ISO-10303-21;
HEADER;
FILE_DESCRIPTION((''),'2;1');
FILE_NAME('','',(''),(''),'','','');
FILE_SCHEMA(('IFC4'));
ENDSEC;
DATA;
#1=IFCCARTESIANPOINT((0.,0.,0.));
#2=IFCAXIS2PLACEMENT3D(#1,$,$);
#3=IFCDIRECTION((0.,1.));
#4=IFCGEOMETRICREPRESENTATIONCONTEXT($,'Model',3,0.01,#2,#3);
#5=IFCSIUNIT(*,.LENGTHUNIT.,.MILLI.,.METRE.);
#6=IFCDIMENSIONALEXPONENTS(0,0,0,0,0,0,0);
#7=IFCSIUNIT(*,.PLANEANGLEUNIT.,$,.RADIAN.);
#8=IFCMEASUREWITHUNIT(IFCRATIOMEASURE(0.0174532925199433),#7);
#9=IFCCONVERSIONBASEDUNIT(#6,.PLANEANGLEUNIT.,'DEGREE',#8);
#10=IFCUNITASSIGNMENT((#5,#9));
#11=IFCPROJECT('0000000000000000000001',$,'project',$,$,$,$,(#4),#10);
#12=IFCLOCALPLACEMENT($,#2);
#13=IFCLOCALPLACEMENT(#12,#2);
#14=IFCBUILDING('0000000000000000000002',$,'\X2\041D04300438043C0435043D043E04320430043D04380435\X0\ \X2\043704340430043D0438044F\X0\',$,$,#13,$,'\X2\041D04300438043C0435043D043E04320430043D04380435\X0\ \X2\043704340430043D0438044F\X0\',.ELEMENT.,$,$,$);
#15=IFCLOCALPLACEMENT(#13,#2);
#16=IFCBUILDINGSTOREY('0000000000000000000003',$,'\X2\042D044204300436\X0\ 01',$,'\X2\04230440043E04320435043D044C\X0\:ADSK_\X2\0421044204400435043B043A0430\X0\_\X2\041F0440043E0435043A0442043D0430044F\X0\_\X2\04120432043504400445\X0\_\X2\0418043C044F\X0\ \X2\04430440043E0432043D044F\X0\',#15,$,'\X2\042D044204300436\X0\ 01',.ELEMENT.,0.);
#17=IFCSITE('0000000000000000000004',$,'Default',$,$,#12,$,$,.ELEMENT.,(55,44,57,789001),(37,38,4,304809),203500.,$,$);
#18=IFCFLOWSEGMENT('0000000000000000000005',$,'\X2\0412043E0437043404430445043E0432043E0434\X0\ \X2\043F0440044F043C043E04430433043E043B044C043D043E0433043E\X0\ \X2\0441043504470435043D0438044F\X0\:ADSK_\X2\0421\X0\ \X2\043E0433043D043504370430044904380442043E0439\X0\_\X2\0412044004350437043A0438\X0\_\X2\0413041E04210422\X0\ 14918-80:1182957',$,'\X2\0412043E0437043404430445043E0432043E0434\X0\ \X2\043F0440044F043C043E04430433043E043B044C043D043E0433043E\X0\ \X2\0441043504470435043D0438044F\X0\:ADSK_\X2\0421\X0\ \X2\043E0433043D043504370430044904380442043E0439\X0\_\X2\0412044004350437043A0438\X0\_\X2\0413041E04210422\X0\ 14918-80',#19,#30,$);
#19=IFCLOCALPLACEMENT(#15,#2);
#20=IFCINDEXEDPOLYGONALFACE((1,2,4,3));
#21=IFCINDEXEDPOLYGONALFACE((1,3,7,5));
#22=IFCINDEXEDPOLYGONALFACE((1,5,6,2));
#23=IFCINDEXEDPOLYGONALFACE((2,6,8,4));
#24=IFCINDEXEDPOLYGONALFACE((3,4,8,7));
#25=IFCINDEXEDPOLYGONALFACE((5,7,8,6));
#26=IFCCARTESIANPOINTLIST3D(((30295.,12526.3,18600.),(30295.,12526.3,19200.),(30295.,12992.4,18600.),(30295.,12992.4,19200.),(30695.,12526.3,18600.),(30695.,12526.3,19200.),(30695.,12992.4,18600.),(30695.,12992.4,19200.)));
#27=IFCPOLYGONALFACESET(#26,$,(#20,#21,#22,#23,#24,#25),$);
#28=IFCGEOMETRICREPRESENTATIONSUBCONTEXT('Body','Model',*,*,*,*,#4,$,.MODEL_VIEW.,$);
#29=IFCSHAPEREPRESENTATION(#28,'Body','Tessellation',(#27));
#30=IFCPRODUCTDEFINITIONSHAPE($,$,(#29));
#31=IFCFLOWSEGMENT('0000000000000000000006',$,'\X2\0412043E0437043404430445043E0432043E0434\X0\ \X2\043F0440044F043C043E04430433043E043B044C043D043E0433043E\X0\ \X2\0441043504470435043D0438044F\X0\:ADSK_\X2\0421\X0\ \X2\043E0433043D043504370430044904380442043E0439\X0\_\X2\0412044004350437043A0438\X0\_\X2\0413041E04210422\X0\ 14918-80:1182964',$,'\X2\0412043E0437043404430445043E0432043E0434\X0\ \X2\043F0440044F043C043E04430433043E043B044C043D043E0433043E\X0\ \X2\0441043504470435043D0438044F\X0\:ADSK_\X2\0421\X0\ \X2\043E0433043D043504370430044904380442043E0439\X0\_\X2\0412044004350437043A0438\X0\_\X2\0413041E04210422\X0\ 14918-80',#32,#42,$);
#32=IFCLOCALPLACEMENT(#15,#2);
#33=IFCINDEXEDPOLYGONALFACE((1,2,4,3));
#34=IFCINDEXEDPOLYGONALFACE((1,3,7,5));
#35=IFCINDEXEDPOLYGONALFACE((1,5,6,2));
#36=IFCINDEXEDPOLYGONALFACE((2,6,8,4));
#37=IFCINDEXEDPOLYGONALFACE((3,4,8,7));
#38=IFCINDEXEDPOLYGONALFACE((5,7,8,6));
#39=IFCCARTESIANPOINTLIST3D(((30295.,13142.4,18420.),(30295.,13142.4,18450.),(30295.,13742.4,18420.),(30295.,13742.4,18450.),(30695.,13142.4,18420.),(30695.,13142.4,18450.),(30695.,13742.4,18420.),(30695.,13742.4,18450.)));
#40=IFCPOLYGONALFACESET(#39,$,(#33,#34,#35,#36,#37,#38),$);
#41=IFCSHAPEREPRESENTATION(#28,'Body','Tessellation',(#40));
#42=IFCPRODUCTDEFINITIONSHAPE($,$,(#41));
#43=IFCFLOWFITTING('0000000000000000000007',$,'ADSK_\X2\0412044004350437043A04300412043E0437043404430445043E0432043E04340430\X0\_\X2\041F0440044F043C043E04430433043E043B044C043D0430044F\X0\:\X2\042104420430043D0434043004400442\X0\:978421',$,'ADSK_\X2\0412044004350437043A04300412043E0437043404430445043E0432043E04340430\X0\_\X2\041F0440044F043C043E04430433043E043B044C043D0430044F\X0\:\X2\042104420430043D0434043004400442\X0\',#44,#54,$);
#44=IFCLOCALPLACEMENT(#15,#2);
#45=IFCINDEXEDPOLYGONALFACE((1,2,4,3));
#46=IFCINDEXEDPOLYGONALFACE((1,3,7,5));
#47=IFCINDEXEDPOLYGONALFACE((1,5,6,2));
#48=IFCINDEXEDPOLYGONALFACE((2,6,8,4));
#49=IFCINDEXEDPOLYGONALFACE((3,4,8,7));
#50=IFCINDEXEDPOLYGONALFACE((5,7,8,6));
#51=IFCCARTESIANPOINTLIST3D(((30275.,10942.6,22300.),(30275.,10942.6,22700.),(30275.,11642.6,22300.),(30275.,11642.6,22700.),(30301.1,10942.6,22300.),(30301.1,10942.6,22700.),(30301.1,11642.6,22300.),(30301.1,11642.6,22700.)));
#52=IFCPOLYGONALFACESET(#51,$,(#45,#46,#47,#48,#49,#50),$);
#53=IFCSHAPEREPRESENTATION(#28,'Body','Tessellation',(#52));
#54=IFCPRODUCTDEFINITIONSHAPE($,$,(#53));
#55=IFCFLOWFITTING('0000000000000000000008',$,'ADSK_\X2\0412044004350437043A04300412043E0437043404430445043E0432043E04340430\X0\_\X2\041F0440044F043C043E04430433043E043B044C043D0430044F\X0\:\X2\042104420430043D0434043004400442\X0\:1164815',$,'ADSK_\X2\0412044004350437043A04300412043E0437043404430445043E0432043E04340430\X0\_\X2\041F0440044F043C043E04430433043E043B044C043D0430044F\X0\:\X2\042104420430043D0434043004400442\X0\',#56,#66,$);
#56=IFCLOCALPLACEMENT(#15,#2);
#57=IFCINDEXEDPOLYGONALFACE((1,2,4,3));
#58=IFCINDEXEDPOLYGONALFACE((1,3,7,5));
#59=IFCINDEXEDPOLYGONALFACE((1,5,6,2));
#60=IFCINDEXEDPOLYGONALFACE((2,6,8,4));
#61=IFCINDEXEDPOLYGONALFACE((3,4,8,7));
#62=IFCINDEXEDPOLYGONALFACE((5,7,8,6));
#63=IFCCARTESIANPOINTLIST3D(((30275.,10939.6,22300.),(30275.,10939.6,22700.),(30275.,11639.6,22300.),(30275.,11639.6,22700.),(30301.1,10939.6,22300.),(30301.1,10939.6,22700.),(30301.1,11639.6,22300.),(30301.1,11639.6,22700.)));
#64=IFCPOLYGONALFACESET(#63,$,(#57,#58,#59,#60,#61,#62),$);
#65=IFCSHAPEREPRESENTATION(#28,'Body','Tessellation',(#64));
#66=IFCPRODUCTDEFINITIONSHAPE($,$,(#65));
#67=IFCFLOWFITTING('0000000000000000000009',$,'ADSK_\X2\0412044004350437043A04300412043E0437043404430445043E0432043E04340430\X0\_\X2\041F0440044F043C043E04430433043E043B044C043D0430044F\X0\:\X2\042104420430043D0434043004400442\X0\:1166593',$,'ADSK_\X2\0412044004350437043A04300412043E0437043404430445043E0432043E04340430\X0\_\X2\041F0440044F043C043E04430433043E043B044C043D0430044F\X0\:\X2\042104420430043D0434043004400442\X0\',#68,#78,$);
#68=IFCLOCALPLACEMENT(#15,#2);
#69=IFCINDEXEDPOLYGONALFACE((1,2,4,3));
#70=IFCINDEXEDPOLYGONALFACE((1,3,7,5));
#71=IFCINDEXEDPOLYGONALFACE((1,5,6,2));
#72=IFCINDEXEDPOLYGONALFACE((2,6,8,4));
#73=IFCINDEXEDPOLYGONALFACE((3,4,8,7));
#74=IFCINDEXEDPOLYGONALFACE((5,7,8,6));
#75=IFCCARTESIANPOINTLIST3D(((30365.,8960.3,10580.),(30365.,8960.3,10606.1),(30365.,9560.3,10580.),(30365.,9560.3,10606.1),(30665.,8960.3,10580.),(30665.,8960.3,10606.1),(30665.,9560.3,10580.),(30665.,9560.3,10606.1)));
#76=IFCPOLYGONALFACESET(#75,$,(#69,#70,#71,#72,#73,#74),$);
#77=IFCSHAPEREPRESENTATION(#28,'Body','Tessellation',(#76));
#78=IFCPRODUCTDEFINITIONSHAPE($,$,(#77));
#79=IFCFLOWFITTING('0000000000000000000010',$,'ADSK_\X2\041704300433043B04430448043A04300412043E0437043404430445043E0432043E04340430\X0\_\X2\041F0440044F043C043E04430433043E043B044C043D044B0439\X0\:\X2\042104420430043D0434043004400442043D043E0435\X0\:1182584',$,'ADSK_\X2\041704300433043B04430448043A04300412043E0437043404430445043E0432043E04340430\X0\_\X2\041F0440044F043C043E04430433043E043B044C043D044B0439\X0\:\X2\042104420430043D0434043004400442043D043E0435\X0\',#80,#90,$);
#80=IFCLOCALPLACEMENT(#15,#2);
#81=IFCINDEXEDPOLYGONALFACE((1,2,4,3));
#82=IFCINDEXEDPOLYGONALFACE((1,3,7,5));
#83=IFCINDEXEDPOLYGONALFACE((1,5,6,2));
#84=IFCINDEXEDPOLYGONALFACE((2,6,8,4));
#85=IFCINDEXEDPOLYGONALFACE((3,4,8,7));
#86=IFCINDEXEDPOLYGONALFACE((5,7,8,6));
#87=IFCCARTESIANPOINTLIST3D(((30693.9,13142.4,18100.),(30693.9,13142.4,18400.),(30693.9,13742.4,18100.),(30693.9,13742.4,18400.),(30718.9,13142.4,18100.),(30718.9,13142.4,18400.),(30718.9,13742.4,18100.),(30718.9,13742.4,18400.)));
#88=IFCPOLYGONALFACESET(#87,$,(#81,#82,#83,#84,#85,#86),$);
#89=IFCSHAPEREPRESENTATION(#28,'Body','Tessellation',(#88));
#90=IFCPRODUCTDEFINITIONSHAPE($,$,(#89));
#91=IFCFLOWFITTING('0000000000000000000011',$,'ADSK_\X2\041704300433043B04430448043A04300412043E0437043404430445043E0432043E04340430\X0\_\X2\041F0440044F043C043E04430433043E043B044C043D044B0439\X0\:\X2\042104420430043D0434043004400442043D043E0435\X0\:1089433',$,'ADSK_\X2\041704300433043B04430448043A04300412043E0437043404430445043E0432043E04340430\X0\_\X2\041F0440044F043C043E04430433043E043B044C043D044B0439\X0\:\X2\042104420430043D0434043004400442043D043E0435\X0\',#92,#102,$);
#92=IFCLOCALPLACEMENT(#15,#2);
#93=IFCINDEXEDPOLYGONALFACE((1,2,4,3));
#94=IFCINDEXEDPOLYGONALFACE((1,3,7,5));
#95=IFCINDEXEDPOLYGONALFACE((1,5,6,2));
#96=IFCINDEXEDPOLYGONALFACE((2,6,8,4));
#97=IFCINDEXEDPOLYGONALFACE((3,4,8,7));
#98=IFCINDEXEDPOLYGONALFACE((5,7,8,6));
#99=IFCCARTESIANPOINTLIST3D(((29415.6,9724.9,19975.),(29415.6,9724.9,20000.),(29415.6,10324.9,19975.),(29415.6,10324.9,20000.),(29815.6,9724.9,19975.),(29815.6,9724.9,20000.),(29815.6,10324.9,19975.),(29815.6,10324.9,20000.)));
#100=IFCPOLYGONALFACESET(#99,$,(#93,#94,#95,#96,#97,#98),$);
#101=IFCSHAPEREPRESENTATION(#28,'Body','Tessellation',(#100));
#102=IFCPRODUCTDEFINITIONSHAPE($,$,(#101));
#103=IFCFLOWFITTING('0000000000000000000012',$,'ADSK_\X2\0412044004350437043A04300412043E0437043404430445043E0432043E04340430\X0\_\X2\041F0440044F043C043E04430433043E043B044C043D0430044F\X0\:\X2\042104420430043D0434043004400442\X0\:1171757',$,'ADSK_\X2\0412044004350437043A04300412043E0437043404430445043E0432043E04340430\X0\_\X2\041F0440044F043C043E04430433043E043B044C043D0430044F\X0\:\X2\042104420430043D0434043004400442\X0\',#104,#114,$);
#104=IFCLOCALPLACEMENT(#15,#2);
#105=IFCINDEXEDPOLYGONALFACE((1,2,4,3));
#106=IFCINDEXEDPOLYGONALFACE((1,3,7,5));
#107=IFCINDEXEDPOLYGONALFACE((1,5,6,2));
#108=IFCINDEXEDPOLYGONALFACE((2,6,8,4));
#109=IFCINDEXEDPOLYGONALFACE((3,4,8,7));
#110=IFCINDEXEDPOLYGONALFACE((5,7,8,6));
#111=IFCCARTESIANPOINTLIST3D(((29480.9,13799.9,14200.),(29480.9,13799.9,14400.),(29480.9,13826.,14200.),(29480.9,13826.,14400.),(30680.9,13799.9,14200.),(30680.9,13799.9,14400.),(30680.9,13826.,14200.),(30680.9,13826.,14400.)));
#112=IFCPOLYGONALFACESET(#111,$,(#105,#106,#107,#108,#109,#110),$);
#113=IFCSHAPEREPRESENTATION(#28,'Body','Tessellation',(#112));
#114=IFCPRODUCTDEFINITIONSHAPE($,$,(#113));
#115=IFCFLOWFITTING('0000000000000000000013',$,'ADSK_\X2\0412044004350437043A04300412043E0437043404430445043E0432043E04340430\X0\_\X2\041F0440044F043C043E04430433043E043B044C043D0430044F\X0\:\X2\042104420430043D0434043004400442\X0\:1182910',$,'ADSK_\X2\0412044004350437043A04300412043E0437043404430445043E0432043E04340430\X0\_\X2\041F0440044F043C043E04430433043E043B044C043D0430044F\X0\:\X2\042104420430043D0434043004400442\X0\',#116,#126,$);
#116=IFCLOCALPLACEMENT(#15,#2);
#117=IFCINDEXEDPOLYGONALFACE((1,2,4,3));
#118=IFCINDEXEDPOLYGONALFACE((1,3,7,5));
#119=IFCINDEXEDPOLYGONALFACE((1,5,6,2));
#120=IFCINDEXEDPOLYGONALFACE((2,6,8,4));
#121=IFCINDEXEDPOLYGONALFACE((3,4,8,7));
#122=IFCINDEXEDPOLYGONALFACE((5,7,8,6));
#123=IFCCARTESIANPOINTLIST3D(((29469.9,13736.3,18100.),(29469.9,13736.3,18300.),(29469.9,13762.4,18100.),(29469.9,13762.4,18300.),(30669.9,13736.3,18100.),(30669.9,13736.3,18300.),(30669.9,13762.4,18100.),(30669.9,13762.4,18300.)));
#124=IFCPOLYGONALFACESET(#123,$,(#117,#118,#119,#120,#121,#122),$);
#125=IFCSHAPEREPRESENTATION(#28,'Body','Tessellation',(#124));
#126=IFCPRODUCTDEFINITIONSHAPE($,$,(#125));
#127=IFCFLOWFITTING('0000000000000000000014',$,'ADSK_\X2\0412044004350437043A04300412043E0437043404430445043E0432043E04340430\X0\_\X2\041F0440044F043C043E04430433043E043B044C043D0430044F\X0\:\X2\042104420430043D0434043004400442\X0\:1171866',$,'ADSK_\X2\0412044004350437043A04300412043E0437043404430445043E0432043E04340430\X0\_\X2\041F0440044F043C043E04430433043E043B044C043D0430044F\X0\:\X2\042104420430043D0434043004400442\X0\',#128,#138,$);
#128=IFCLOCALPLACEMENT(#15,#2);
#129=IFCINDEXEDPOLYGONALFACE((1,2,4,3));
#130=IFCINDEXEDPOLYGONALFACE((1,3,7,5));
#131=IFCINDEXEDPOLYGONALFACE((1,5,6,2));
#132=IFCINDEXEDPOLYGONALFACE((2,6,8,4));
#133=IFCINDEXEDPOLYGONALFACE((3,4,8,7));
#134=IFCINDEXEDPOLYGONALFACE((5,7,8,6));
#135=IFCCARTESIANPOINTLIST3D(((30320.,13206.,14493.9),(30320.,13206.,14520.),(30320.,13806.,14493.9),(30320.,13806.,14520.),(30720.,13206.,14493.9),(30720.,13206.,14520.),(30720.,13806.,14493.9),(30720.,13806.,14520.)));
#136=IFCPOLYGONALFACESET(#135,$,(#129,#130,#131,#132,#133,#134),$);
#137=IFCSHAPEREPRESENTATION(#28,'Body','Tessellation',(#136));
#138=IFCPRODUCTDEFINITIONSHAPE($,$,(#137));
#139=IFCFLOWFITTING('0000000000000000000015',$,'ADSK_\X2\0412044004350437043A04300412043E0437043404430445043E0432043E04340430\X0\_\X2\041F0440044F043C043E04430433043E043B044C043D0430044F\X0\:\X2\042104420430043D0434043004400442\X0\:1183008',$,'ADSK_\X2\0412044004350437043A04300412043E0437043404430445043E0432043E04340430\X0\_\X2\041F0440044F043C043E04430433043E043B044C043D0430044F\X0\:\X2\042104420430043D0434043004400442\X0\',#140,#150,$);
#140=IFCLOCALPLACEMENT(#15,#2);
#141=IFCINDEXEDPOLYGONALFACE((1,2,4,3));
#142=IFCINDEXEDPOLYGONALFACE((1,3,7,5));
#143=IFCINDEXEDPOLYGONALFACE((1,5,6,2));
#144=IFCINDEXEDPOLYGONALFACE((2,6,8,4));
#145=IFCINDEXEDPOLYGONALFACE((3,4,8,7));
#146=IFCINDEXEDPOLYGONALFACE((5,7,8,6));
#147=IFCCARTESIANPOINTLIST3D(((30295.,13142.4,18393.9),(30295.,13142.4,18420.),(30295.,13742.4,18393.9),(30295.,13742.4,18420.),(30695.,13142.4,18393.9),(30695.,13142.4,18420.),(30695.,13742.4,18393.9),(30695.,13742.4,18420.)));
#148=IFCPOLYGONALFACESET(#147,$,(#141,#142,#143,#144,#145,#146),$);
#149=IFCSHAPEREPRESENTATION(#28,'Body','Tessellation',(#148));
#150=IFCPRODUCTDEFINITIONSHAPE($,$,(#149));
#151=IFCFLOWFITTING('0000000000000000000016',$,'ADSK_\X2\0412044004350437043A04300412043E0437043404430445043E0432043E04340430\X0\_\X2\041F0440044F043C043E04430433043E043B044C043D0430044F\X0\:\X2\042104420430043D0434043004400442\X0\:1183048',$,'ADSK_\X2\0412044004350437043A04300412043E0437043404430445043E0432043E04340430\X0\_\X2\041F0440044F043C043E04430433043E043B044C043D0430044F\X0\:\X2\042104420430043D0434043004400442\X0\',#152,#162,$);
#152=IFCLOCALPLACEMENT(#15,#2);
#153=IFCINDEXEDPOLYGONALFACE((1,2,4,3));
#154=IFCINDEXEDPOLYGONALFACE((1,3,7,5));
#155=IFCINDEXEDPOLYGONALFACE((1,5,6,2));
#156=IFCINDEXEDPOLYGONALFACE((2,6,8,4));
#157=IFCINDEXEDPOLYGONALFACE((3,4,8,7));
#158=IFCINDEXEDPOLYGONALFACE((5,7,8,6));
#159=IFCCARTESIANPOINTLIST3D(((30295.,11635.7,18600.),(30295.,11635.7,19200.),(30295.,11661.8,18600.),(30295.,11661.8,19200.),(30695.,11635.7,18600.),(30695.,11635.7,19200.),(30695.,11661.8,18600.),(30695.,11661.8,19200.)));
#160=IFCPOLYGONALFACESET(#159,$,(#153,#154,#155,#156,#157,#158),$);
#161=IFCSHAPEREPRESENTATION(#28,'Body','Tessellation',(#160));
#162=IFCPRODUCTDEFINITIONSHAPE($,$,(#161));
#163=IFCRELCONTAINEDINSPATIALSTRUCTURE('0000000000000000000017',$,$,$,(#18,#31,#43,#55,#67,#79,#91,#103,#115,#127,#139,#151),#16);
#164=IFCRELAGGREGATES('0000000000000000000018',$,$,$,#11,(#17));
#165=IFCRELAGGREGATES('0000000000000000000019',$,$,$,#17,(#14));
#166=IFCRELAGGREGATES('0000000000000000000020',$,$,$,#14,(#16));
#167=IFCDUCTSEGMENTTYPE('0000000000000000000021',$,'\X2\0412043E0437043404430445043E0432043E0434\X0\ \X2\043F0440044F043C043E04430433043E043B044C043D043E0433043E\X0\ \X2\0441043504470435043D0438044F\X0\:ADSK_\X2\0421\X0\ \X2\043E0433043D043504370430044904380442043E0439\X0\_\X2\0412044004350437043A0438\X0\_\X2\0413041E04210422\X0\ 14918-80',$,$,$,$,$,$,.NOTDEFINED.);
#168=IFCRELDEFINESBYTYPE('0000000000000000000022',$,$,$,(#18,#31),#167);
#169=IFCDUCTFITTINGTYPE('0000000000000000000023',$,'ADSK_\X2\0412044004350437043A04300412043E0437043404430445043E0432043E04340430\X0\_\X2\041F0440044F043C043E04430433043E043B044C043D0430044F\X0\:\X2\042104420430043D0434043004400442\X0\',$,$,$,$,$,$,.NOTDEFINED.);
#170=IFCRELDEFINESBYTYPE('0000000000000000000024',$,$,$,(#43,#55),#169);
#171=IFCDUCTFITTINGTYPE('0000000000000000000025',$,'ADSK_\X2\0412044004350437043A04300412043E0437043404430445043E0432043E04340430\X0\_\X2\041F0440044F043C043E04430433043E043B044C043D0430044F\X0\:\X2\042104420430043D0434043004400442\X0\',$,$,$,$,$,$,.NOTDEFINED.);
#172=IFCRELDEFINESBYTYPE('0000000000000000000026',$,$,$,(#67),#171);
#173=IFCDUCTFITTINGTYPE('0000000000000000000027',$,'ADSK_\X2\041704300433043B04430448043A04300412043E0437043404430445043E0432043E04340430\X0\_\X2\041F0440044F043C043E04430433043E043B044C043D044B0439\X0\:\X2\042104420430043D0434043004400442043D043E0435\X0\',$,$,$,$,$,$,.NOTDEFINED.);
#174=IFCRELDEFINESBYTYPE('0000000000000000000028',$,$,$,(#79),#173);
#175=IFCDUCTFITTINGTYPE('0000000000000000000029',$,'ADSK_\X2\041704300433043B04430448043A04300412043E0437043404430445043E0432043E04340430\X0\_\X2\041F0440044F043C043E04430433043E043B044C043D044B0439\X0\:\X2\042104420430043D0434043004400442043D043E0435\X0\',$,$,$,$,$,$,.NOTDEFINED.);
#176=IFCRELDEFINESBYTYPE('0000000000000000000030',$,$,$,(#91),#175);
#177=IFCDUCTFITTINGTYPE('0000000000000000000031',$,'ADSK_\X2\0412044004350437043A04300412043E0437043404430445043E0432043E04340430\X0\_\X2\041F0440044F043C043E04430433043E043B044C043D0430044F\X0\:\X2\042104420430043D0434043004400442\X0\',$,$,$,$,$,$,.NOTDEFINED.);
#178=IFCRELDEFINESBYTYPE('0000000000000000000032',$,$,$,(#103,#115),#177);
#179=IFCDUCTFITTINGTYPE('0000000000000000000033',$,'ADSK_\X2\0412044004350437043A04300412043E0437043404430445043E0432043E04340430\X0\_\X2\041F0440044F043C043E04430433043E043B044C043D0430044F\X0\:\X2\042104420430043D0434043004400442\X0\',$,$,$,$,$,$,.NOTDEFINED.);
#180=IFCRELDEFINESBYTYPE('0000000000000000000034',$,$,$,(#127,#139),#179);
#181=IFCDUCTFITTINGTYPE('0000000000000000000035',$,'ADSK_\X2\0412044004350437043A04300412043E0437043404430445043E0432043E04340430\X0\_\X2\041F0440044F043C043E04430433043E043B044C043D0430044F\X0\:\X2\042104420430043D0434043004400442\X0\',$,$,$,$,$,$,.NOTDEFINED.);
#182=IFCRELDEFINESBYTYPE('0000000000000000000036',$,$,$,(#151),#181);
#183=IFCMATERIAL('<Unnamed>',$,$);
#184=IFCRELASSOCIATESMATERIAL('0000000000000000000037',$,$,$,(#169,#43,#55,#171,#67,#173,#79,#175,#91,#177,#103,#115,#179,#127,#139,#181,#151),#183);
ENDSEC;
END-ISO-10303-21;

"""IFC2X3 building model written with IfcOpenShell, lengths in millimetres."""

from ifc_helpers import new_model, entity, si_unit, converted_unit, direction, frame, origin, origin_2d_with_axis, place, context, subcontext, project, spatial, rectangle, extrude, source, transform, mapped, material, type_object, type_shapes, element, save


model = new_model("IFC2X3")

# Units and contexts
model_context = context("Model", 3, precision=0.01, world=origin(), true_north=direction((0.0, 1.0)))
body_context = subcontext(model_context, "Body", "Model", "MODEL_VIEW")
ifc_project = project(units=[si_unit("LENGTHUNIT", "METRE", prefix="MILLI"), converted_unit("PLANEANGLEUNIT", "DEGREE", entity("IfcRatioMeasure", 0.0174532925199433), si_unit("PLANEANGLEUNIT", "RADIAN"), dimensions=[0, 0, 0, 0, 0, 0, 0])], contexts=[model_context])

# Site, building, storey
site_placement = place(None, origin())
site = spatial("IfcSite", under=ifc_project, at=site_placement, Name="Default", CompositionType="ELEMENT", RefLatitude=(55, 44, 57, 789001), RefLongitude=(37, 38, 4, 304809), RefElevation=203500.0)
building_placement = place(site_placement, origin())
building = spatial("IfcBuilding", under=site, at=building_placement, Name="Наименование здания", LongName="Наименование здания", CompositionType="ELEMENT")
storey_placement = place(building_placement, origin())
storey = spatial("IfcBuildingStorey", under=building, at=storey_placement, Name="Этаж 01", ObjectType="Уровень:ADSK_Стрелка_Проектная_Вверх_Имя уровня", LongName="Этаж 01", CompositionType="ELEMENT", Elevation=0.0)

# Flow segments
duct_segment_type = type_object("IfcDuctSegmentType", Name="Воздуховод прямоугольного сечения:ADSK_С огнезащитой_Врезки_ГОСТ 14918-80", PredefinedType="NOTDEFINED")
flow_segment_1_placement = place(storey_placement, frame((30295.0, 12526.3, 18600.0)))
element("IfcFlowSegment", 1, at=flow_segment_1_placement, inside=storey, type_object=duct_segment_type, Name="Воздуховод прямоугольного сечения:ADSK_С огнезащитой_Врезки_ГОСТ 14918-80:1182957", ObjectType="Воздуховод прямоугольного сечения:ADSK_С огнезащитой_Врезки_ГОСТ 14918-80", context=body_context, shape_type="SweptSolid", body=[
    extrude(rectangle(XDim=466.0, YDim=400.0, at=origin_2d_with_axis()), frame((200.0, 233.0, 0.0), z_axis=(0.0, 0.0, 1.0), x_axis=(0.0, 1.0, 0.0)), (0.0, 0.0, 1.0), 600.0),
])
flow_segment_2_placement = place(storey_placement, frame((30295.0, 13142.4, 18420.0)))
element("IfcFlowSegment", 2, at=flow_segment_2_placement, inside=storey, type_object=duct_segment_type, Name="Воздуховод прямоугольного сечения:ADSK_С огнезащитой_Врезки_ГОСТ 14918-80:1182964", ObjectType="Воздуховод прямоугольного сечения:ADSK_С огнезащитой_Врезки_ГОСТ 14918-80", context=body_context, shape_type="SweptSolid", body=[
    extrude(rectangle(XDim=400.0, YDim=600.0, at=origin_2d_with_axis()), frame((200.0, 300.0, 0.0)), (0.0, 0.0, 1.0), 30.0),
])

# Flow fittings
ifc_material_1 = material(Name="<Unnamed>")
duct_fitting_type_1 = type_object("IfcDuctFittingType", Name="ADSK_ВрезкаВоздуховода_Прямоугольная:Стандарт", PredefinedType="NOTDEFINED", material=ifc_material_1)
shared_shape_1 = source(origin(), body_context, "Body", "SweptSolid", [
    extrude(rectangle(XDim=26.1, YDim=400.0, at=origin_2d_with_axis()), frame((7.0, 0.0, -350.0)), (0.0, 0.0, 1.0), 700.0),
])
type_shapes(duct_fitting_type_1, [shared_shape_1])
for number, where, z_axis, x_axis, name in (
    (3, (30295.0, 11292.6, 22500.0), (0.0, 1.0, 0.0), (-1.0, 0.0, 0.0), "ADSK_ВрезкаВоздуховода_Прямоугольная:Стандарт:978421"),
    (4, (30295.0, 11289.6, 22500.0), (0.0, 1.0, 0.0), (-1.0, 0.0, 0.0), "ADSK_ВрезкаВоздуховода_Прямоугольная:Стандарт:1164815"),
):
    element("IfcFlowFitting", number, at=place(storey_placement, frame(where, z_axis=z_axis, x_axis=x_axis)), inside=storey, type_object=duct_fitting_type_1, material=ifc_material_1, Name=name, ObjectType="ADSK_ВрезкаВоздуховода_Прямоугольная:Стандарт", context=body_context, shape_type="MappedRepresentation", body=[
        mapped(shared_shape_1, transform((0.0, 0.0, 0.0), scale=1.0)),
    ])
duct_fitting_type_2 = type_object("IfcDuctFittingType", Name="ADSK_ВрезкаВоздуховода_Прямоугольная:Стандарт", PredefinedType="NOTDEFINED", material=ifc_material_1)
shared_shape_2 = source(origin(), body_context, "Body", "SweptSolid", [
    extrude(rectangle(XDim=26.1, YDim=600.0, at=origin_2d_with_axis()), frame((7.0, 0.0, -150.0)), (0.0, 0.0, 1.0), 300.0),
])
type_shapes(duct_fitting_type_2, [shared_shape_2])
flow_fitting_1_placement = place(storey_placement, frame((30515.0, 9260.3, 10600.0), z_axis=(1.0, 0.0, 0.0), x_axis=(0.0, 0.0, -1.0)))
element("IfcFlowFitting", 5, at=flow_fitting_1_placement, inside=storey, type_object=duct_fitting_type_2, material=ifc_material_1, Name="ADSK_ВрезкаВоздуховода_Прямоугольная:Стандарт:1166593", ObjectType="ADSK_ВрезкаВоздуховода_Прямоугольная:Стандарт", context=body_context, shape_type="MappedRepresentation", body=[
    mapped(shared_shape_2, transform((0.0, 0.0, 0.0), scale=1.0)),
])
duct_fitting_type_3 = type_object("IfcDuctFittingType", Name="ADSK_ЗаглушкаВоздуховода_Прямоугольный:Стандартное", PredefinedType="NOTDEFINED", material=ifc_material_1)
shared_shape_3 = source(origin(), body_context, "Body", "SweptSolid", [
    extrude(rectangle(XDim=25.0, YDim=600.0, at=origin_2d_with_axis()), frame((12.5, 0.0, -150.0)), (0.0, 0.0, 1.0), 300.0),
])
type_shapes(duct_fitting_type_3, [shared_shape_3])
flow_fitting_2_placement = place(storey_placement, frame((30693.9, 13442.4, 18250.0)))
element("IfcFlowFitting", 6, at=flow_fitting_2_placement, inside=storey, type_object=duct_fitting_type_3, material=ifc_material_1, Name="ADSK_ЗаглушкаВоздуховода_Прямоугольный:Стандартное:1182584", ObjectType="ADSK_ЗаглушкаВоздуховода_Прямоугольный:Стандартное", context=body_context, shape_type="MappedRepresentation", body=[
    mapped(shared_shape_3, transform((0.0, 0.0, 0.0), scale=1.0)),
])
duct_fitting_type_4 = type_object("IfcDuctFittingType", Name="ADSK_ЗаглушкаВоздуховода_Прямоугольный:Стандартное", PredefinedType="NOTDEFINED", material=ifc_material_1)
shared_shape_4 = source(origin(), body_context, "Body", "SweptSolid", [
    extrude(rectangle(XDim=25.0, YDim=600.0, at=origin_2d_with_axis()), frame((12.5, 0.0, -200.0)), (0.0, 0.0, 1.0), 400.0),
])
type_shapes(duct_fitting_type_4, [shared_shape_4])
flow_fitting_3_placement = place(storey_placement, frame((29615.6, 10024.9, 20000.0), z_axis=(1.0, 0.0, 0.0), x_axis=(0.0, 0.0, -1.0)))
element("IfcFlowFitting", 7, at=flow_fitting_3_placement, inside=storey, type_object=duct_fitting_type_4, material=ifc_material_1, Name="ADSK_ЗаглушкаВоздуховода_Прямоугольный:Стандартное:1089433", ObjectType="ADSK_ЗаглушкаВоздуховода_Прямоугольный:Стандартное", context=body_context, shape_type="MappedRepresentation", body=[
    mapped(shared_shape_4, transform((0.0, 0.0, 0.0), scale=1.0)),
])
duct_fitting_type_5 = type_object("IfcDuctFittingType", Name="ADSK_ВрезкаВоздуховода_Прямоугольная:Стандарт", PredefinedType="NOTDEFINED", material=ifc_material_1)
shared_shape_5 = source(origin(), body_context, "Body", "SweptSolid", [
    extrude(rectangle(XDim=26.1, YDim=1200.0, at=origin_2d_with_axis()), frame((7.0, 0.0, -100.0)), (0.0, 0.0, 1.0), 200.0),
])
type_shapes(duct_fitting_type_5, [shared_shape_5])
for number, where, z_axis, x_axis, name in (
    (8, (30080.9, 13806.0, 14300.0), (0.0, 0.0, -1.0), (0.0, 1.0, 0.0), "ADSK_ВрезкаВоздуховода_Прямоугольная:Стандарт:1171757"),
    (9, (30069.9, 13742.4, 18200.0), (0.0, 0.0, 1.0), (0.0, 1.0, 0.0), "ADSK_ВрезкаВоздуховода_Прямоугольная:Стандарт:1182910"),
):
    element("IfcFlowFitting", number, at=place(storey_placement, frame(where, z_axis=z_axis, x_axis=x_axis)), inside=storey, type_object=duct_fitting_type_5, material=ifc_material_1, Name=name, ObjectType="ADSK_ВрезкаВоздуховода_Прямоугольная:Стандарт", context=body_context, shape_type="MappedRepresentation", body=[
        mapped(shared_shape_5, transform((0.0, 0.0, 0.0), scale=1.0)),
    ])
duct_fitting_type_6 = type_object("IfcDuctFittingType", Name="ADSK_ВрезкаВоздуховода_Прямоугольная:Стандарт", PredefinedType="NOTDEFINED", material=ifc_material_1)
shared_shape_6 = source(origin(), body_context, "Body", "SweptSolid", [
    extrude(rectangle(XDim=400.0, YDim=26.1, at=origin_2d_with_axis()), frame((7.0, 0.0, -300.0), z_axis=(0.0, 0.0, 1.0), x_axis=(0.0, -1.0, 0.0)), (0.0, 0.0, 1.0), 600.0),
])
type_shapes(duct_fitting_type_6, [shared_shape_6])
for number, where, z_axis, x_axis, name in (
    (10, (30520.0, 13506.0, 14500.0), (0.0, -1.0, 0.0), (0.0, 0.0, 1.0), "ADSK_ВрезкаВоздуховода_Прямоугольная:Стандарт:1171866"),
    (11, (30495.0, 13442.4, 18400.0), (0.0, 1.0, 0.0), (0.0, 0.0, 1.0), "ADSK_ВрезкаВоздуховода_Прямоугольная:Стандарт:1183008"),
):
    element("IfcFlowFitting", number, at=place(storey_placement, frame(where, z_axis=z_axis, x_axis=x_axis)), inside=storey, type_object=duct_fitting_type_6, material=ifc_material_1, Name=name, ObjectType="ADSK_ВрезкаВоздуховода_Прямоугольная:Стандарт", context=body_context, shape_type="MappedRepresentation", body=[
        mapped(shared_shape_6, transform((0.0, 0.0, 0.0), scale=1.0)),
    ])
duct_fitting_type_7 = type_object("IfcDuctFittingType", Name="ADSK_ВрезкаВоздуховода_Прямоугольная:Стандарт", PredefinedType="NOTDEFINED", material=ifc_material_1)
shared_shape_7 = source(origin(), body_context, "Body", "SweptSolid", [
    extrude(rectangle(XDim=26.2, YDim=600.0, at=origin_2d_with_axis()), frame((7.0, 0.0, -200.0)), (0.0, 0.0, 1.0), 400.0),
])
type_shapes(duct_fitting_type_7, [shared_shape_7])
flow_fitting_4_placement = place(storey_placement, frame((30495.0, 11641.8, 18900.0), z_axis=(1.0, 0.0, 0.0), x_axis=(0.0, 1.0, 0.0)))
element("IfcFlowFitting", 12, at=flow_fitting_4_placement, inside=storey, type_object=duct_fitting_type_7, material=ifc_material_1, Name="ADSK_ВрезкаВоздуховода_Прямоугольная:Стандарт:1183048", ObjectType="ADSK_ВрезкаВоздуховода_Прямоугольная:Стандарт", context=body_context, shape_type="MappedRepresentation", body=[
    mapped(shared_shape_7, transform((0.0, 0.0, 0.0), scale=1.0)),
])

save(model, "model.ifc")
